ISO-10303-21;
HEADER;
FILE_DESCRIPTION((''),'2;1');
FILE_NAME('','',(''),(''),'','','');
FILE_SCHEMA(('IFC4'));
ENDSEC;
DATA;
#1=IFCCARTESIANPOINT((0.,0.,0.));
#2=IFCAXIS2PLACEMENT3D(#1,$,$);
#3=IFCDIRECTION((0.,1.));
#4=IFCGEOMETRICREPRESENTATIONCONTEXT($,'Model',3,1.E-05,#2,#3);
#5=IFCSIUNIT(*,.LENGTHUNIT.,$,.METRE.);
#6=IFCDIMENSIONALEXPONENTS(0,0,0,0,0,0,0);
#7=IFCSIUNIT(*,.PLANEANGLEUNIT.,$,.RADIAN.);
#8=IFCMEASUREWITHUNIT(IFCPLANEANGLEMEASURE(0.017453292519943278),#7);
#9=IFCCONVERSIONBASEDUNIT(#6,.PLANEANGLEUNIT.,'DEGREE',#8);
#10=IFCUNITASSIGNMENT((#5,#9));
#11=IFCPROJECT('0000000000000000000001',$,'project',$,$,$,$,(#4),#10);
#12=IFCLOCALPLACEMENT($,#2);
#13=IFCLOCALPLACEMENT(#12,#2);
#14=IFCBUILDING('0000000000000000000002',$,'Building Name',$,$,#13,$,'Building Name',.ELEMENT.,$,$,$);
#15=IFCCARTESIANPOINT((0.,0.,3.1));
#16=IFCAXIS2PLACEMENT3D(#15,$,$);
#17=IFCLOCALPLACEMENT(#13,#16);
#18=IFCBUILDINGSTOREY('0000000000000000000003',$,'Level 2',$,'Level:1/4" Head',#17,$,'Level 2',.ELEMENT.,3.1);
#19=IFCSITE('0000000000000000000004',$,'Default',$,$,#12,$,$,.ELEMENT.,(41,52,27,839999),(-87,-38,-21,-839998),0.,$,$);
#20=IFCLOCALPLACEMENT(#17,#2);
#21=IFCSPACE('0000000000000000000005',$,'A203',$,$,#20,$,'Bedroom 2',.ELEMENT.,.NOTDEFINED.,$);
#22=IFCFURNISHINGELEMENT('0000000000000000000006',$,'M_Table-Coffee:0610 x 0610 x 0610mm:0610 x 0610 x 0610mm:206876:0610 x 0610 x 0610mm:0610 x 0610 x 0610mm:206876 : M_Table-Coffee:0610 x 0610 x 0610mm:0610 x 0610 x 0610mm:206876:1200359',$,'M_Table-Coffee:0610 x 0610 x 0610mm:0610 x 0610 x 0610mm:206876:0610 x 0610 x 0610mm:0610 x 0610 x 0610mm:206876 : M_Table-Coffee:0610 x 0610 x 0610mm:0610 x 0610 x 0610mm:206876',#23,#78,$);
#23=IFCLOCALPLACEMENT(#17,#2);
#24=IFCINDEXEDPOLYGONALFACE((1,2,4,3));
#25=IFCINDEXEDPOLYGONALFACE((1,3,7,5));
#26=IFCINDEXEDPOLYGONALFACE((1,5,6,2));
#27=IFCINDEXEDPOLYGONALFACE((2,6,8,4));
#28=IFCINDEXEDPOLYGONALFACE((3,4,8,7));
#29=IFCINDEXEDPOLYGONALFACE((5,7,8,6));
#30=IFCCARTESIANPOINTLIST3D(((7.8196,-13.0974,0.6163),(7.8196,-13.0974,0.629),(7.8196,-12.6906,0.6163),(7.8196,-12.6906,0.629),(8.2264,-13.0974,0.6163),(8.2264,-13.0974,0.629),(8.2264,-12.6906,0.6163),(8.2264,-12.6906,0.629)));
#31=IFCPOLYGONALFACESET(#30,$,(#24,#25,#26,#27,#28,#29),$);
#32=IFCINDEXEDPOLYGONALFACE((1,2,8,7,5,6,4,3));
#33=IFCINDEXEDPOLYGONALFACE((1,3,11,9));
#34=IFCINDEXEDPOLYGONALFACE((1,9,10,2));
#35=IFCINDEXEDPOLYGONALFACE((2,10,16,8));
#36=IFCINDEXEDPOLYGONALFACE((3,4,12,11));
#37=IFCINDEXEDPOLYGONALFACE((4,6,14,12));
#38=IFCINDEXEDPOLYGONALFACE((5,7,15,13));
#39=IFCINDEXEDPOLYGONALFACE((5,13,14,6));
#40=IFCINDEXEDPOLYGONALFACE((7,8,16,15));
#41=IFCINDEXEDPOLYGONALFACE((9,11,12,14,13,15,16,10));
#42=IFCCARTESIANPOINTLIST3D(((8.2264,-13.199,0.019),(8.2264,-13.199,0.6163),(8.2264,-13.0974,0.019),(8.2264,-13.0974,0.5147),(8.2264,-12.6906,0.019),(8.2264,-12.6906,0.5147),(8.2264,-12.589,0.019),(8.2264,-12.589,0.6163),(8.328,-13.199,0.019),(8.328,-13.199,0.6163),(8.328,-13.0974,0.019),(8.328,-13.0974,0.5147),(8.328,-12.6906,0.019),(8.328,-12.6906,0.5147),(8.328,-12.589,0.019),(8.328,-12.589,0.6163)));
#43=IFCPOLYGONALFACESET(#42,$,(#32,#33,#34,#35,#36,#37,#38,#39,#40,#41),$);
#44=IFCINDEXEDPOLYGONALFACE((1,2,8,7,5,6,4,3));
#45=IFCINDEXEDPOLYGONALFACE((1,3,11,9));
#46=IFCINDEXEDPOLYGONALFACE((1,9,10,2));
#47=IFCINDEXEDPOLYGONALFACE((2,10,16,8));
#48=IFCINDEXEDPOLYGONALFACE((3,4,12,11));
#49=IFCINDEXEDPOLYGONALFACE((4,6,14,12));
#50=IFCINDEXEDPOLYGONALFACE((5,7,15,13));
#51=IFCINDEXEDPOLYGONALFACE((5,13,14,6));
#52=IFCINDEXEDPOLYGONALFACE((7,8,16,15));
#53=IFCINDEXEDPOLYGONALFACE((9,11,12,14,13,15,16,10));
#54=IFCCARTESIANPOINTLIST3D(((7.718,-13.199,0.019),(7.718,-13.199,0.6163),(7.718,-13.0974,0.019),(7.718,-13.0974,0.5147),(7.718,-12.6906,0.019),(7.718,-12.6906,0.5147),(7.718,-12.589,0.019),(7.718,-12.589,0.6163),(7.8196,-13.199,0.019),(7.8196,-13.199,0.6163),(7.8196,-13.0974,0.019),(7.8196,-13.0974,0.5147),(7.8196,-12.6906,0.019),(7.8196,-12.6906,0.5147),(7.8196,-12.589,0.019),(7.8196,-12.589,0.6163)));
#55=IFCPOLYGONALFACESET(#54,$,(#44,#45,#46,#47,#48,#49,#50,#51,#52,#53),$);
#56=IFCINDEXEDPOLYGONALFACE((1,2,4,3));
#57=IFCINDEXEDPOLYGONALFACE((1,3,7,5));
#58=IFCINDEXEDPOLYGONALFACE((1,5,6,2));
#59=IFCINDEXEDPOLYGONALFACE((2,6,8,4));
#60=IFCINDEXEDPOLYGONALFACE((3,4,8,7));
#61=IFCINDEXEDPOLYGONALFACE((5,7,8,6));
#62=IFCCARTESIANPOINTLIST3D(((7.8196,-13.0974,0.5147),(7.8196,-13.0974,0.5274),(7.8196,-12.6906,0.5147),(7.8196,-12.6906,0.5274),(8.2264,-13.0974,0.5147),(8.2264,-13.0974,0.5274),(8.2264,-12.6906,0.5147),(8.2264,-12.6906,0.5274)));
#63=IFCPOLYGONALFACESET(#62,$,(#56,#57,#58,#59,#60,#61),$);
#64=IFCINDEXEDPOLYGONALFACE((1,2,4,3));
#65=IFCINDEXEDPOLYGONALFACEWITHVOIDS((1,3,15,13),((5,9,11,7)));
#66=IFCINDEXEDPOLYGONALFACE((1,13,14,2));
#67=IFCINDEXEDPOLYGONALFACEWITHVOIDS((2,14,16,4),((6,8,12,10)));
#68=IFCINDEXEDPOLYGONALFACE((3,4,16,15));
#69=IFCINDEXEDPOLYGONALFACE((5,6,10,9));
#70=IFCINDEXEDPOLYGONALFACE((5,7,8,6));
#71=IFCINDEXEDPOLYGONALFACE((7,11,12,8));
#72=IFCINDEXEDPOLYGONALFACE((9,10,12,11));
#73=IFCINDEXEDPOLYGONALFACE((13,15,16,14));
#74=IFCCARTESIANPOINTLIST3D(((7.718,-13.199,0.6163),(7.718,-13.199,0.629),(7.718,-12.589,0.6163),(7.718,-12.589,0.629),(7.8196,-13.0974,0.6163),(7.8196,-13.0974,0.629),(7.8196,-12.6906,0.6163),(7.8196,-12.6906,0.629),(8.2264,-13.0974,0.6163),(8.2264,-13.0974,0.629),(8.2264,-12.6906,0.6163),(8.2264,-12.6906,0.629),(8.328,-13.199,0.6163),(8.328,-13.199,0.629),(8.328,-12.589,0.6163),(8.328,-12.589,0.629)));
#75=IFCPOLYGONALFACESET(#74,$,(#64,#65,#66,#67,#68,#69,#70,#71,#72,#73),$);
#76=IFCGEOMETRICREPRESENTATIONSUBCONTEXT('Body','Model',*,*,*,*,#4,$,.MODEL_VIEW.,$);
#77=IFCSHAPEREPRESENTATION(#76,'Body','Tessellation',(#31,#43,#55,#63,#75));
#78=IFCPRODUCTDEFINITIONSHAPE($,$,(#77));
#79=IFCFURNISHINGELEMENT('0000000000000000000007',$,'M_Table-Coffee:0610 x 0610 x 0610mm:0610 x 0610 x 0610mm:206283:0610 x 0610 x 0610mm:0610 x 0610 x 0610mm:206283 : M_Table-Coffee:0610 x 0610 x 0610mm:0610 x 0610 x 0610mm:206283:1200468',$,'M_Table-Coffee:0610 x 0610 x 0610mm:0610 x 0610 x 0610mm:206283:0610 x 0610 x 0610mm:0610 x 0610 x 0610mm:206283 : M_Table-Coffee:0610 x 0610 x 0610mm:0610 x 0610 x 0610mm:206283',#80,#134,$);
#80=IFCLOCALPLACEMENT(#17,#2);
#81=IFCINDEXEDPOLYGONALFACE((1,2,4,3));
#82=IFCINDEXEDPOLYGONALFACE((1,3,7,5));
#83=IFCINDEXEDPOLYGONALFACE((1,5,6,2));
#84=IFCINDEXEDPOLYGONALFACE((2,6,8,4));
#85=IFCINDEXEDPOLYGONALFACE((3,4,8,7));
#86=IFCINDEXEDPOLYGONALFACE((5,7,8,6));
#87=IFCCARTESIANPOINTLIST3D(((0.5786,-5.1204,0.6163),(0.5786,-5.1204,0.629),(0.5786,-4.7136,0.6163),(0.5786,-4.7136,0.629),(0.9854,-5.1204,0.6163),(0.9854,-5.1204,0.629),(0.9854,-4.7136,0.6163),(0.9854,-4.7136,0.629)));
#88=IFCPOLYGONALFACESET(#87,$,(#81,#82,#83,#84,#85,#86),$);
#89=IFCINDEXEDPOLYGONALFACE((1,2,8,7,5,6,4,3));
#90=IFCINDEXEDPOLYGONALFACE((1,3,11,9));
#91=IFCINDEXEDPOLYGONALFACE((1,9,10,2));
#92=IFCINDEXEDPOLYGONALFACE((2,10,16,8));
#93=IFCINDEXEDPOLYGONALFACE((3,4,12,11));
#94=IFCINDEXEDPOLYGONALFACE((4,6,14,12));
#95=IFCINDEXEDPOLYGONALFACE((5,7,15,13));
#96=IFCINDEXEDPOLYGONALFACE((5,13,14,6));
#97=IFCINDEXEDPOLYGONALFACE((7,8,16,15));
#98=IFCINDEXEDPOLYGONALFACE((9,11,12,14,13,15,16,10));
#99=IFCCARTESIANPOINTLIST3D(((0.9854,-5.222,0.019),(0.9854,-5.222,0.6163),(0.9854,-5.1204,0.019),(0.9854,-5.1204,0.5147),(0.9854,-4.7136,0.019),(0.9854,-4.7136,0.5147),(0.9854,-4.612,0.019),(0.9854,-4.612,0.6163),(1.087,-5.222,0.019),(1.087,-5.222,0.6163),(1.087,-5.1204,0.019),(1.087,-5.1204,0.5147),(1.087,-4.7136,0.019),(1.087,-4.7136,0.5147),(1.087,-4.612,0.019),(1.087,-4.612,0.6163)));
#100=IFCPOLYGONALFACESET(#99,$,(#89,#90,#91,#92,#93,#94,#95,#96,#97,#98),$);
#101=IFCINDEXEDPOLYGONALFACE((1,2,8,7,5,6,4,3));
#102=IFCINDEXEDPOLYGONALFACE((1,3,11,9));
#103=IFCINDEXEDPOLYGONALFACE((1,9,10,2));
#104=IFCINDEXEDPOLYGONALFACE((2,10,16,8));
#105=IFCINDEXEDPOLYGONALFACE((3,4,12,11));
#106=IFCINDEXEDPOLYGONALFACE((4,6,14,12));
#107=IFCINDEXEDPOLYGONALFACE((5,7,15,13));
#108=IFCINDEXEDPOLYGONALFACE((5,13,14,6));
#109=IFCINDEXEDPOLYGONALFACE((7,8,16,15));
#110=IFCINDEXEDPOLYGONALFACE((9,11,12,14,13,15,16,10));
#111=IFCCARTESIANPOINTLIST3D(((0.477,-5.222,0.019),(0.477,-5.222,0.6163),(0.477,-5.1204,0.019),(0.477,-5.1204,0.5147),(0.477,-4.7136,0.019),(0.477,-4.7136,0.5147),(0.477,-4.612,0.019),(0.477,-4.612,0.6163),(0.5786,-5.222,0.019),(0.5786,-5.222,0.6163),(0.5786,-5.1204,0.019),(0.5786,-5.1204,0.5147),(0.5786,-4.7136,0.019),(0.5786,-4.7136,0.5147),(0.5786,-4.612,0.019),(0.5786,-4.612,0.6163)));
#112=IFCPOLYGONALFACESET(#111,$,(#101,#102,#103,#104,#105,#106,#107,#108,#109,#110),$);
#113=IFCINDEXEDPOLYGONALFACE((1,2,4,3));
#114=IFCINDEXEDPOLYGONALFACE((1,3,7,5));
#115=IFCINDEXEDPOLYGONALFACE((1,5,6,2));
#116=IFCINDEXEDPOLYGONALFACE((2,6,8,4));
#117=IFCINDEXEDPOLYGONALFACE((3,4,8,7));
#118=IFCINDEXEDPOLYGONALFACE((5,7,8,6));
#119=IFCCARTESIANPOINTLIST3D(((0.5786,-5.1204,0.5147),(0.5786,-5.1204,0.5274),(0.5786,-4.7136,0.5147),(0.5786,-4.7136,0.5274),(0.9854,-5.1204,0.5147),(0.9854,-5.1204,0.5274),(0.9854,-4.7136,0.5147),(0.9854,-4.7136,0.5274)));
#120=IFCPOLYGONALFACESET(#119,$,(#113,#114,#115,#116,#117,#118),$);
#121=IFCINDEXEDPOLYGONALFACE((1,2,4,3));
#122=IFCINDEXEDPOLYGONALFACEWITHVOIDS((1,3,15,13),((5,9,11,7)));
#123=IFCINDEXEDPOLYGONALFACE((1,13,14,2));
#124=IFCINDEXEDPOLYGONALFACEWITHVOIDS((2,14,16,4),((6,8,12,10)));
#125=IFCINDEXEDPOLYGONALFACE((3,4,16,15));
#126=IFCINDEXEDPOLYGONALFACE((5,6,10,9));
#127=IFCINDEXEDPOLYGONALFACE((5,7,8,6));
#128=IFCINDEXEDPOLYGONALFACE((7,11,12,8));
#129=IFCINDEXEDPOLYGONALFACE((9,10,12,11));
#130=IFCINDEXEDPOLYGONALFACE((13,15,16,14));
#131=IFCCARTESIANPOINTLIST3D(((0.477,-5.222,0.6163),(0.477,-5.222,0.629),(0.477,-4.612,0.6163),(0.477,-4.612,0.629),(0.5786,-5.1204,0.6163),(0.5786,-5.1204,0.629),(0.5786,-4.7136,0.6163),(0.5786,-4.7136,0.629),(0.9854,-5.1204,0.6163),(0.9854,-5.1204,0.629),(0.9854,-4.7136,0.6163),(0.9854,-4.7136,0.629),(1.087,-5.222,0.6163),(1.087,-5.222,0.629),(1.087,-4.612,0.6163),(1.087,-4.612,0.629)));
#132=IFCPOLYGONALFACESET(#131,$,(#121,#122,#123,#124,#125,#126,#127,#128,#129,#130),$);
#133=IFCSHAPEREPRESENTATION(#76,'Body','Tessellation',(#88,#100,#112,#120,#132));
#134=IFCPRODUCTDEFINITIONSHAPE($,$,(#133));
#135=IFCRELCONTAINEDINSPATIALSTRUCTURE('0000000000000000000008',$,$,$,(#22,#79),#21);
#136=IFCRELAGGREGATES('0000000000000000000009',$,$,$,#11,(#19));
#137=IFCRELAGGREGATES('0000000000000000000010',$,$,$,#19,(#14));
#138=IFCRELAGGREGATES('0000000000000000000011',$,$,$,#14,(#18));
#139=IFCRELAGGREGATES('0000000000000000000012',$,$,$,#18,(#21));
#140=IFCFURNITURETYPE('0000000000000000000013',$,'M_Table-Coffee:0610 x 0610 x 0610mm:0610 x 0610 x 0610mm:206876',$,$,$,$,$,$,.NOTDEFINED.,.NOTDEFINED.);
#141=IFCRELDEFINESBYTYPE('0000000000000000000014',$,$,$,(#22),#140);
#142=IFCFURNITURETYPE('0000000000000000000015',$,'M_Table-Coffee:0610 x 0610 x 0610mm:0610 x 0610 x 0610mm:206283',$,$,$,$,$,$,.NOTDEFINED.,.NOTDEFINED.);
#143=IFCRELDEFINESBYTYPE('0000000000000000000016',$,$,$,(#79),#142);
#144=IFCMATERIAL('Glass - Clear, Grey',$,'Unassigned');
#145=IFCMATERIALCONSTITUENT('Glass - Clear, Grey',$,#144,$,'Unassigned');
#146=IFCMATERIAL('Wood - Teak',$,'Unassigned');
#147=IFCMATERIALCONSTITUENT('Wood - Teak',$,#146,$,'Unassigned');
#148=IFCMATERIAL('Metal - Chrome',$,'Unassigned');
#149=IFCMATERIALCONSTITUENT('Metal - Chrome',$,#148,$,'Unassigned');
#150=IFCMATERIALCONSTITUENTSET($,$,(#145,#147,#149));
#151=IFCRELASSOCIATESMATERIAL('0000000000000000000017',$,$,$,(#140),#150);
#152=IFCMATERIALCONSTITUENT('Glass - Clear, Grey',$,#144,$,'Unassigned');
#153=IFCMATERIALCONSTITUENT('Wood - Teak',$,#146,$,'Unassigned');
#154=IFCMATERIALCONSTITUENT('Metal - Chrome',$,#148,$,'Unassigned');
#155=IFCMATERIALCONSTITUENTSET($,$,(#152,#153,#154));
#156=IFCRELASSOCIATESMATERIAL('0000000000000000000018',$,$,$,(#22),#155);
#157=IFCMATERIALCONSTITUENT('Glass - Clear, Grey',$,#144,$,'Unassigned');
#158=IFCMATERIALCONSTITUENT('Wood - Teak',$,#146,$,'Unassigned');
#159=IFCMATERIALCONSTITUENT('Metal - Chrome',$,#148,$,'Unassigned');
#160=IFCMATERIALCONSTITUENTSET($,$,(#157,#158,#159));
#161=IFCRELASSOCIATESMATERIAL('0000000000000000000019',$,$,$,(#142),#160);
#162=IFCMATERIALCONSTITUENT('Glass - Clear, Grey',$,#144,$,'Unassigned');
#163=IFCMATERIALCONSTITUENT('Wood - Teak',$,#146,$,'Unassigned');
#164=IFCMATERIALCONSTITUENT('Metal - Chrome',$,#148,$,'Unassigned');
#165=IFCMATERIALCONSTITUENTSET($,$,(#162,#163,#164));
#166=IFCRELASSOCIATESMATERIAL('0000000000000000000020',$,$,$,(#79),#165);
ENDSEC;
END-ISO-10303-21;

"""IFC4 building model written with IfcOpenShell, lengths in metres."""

from ifc_helpers import new_model, entity, si_unit, converted_unit, direction, frame, origin, place, context, subcontext, project, spatial, indexed_curve, outline, extrude, source, transform, mapped, material, constituent, constituent_set, type_object, type_shapes, element, save


model = new_model("IFC4")

# Units and contexts
model_context = context("Model", 3, precision=1e-05, world=origin(), true_north=direction((0.0, 1.0)))
body_context = subcontext(model_context, "Body", "Model", "MODEL_VIEW")
ifc_project = project(units=[si_unit("LENGTHUNIT", "METRE"), converted_unit("PLANEANGLEUNIT", "DEGREE", entity("IfcPlaneAngleMeasure", 0.017453292519943278), si_unit("PLANEANGLEUNIT", "RADIAN"), dimensions=[0, 0, 0, 0, 0, 0, 0])], contexts=[model_context])

# Site, building, storey
site_placement = place(None, origin())
site = spatial("IfcSite", under=ifc_project, at=site_placement, Name="Default", CompositionType="ELEMENT", RefLatitude=(41, 52, 27, 839999), RefLongitude=(-87, -38, -21, -839998), RefElevation=0.0)
building_placement = place(site_placement, origin())
building = spatial("IfcBuilding", under=site, at=building_placement, Name="Building Name", LongName="Building Name", CompositionType="ELEMENT")
storey_placement = place(building_placement, frame((0.0, 0.0, 3.1)))
storey = spatial("IfcBuildingStorey", under=building, at=storey_placement, Name="Level 2", ObjectType="Level:1/4\" Head", LongName="Level 2", CompositionType="ELEMENT", Elevation=3.1)

# Shared definitions
space_placement = place(storey_placement, origin())
space = spatial("IfcSpace", under=storey, at=space_placement, Name="A203", LongName="Bedroom 2", CompositionType="ELEMENT", PredefinedType="NOTDEFINED")

# Furnishing elements
ifc_material_1 = material(Name="Glass - Clear, Grey", Category="Unassigned")
ifc_constituent_1 = constituent(ifc_material_1, Name="Glass - Clear, Grey", Category="Unassigned")
ifc_material_2 = material(Name="Wood - Teak", Category="Unassigned")
ifc_constituent_2 = constituent(ifc_material_2, Name="Wood - Teak", Category="Unassigned")
ifc_material_3 = material(Name="Metal - Chrome", Category="Unassigned")
ifc_constituent_3 = constituent(ifc_material_3, Name="Metal - Chrome", Category="Unassigned")
ifc_constituent_set_1 = constituent_set(constituents=[ifc_constituent_1, ifc_constituent_2, ifc_constituent_3])
ifc_constituent_4 = constituent(ifc_material_1, Name="Glass - Clear, Grey", Category="Unassigned")
ifc_constituent_5 = constituent(ifc_material_2, Name="Wood - Teak", Category="Unassigned")
ifc_constituent_6 = constituent(ifc_material_3, Name="Metal - Chrome", Category="Unassigned")
ifc_constituent_set_2 = constituent_set(constituents=[ifc_constituent_4, ifc_constituent_5, ifc_constituent_6])
furniture_type_1 = type_object("IfcFurnitureType", Name="M_Table-Coffee:0610 x 0610 x 0610mm:0610 x 0610 x 0610mm:206876", AssemblyPlace="NOTDEFINED", PredefinedType="NOTDEFINED", material=ifc_constituent_set_2)
shared_shape_1 = source(origin(), body_context, "Body", "SweptSolid", [
    extrude(outline(indexed_curve([(-0.2034, -0.2034), (0.2034, -0.2034), (0.2034, 0.2034), (-0.2034, 0.2034), (-0.2034, -0.2034)], self_intersect=False)), frame((8.023, -12.894, 3.7163), z_axis=(0.0, 0.0, 1.0), x_axis=(0.0, -1.0, 0.0)), (0.0, 0.0, 1.0), 0.0127),
    extrude(outline(indexed_curve([(-0.305, -0.324), (0.305, -0.324), (0.305, 0.2732), (0.2034, 0.2732), (0.2034, -0.2225), (-0.2034, -0.2225), (-0.2034, 0.2732), (-0.305, 0.2732), (-0.305, -0.324)], self_intersect=False)), frame((8.2264, -12.894, 3.3923), z_axis=(1.0, 0.0, 0.0), x_axis=(0.0, -1.0, 0.0)), (0.0, 0.0, 1.0), 0.1016),
    extrude(outline(indexed_curve([(-0.3241, -0.305), (0.2733, -0.305), (0.2733, -0.2034), (-0.2224, -0.2034), (-0.2224, 0.2034), (0.2733, 0.2034), (0.2733, 0.305), (-0.3241, 0.305), (-0.3241, -0.305)], self_intersect=False)), frame((7.718, -12.894, 3.3923), z_axis=(1.0, 0.0, 0.0), x_axis=(0.0, 0.0, -1.0)), (0.0, 0.0, 1.0), 0.1016),
    extrude(outline(indexed_curve([(-0.2034, -0.2034), (0.2034, -0.2034), (0.2034, 0.2034), (-0.2034, 0.2034), (-0.2034, -0.2034)], self_intersect=False)), frame((8.023, -12.894, 3.6147), z_axis=(0.0, 0.0, 1.0), x_axis=(0.0, -1.0, 0.0)), (0.0, 0.0, 1.0), 0.0127),
    extrude(outline(indexed_curve([(-0.305, -0.305), (0.305, -0.305), (0.305, 0.305), (-0.305, 0.305), (-0.305, -0.305)], self_intersect=False), holes=[indexed_curve([(0.2034, 0.2034), (0.2034, -0.2034), (-0.2034, -0.2034), (-0.2034, 0.2034), (0.2034, 0.2034)], self_intersect=False)]), frame((8.023, -12.894, 3.7163), z_axis=(0.0, 0.0, 1.0), x_axis=(0.0, -1.0, 0.0)), (0.0, 0.0, 1.0), 0.0127),
])
type_shapes(furniture_type_1, [shared_shape_1])
furnishing_1_placement = place(space_placement, frame((0.0, 0.0, -3.1)))
element("IfcFurnishingElement", 1, at=furnishing_1_placement, inside=space, type_object=furniture_type_1, material=ifc_constituent_set_1, Name="M_Table-Coffee:0610 x 0610 x 0610mm:0610 x 0610 x 0610mm:206876:0610 x 0610 x 0610mm:0610 x 0610 x 0610mm:206876 : M_Table-Coffee:0610 x 0610 x 0610mm:0610 x 0610 x 0610mm:206876:1200359", ObjectType="M_Table-Coffee:0610 x 0610 x 0610mm:0610 x 0610 x 0610mm:206876:0610 x 0610 x 0610mm:0610 x 0610 x 0610mm:206876 : M_Table-Coffee:0610 x 0610 x 0610mm:0610 x 0610 x 0610mm:206876", context=body_context, shape_type="MappedRepresentation", body=[
    mapped(shared_shape_1, transform((0.0, 0.0, 0.0), scale=1.0)),
])
ifc_constituent_7 = constituent(ifc_material_1, Name="Glass - Clear, Grey", Category="Unassigned")
ifc_constituent_8 = constituent(ifc_material_2, Name="Wood - Teak", Category="Unassigned")
ifc_constituent_9 = constituent(ifc_material_3, Name="Metal - Chrome", Category="Unassigned")
ifc_constituent_set_3 = constituent_set(constituents=[ifc_constituent_7, ifc_constituent_8, ifc_constituent_9])
ifc_constituent_10 = constituent(ifc_material_1, Name="Glass - Clear, Grey", Category="Unassigned")
ifc_constituent_11 = constituent(ifc_material_2, Name="Wood - Teak", Category="Unassigned")
ifc_constituent_12 = constituent(ifc_material_3, Name="Metal - Chrome", Category="Unassigned")
ifc_constituent_set_4 = constituent_set(constituents=[ifc_constituent_10, ifc_constituent_11, ifc_constituent_12])
furniture_type_2 = type_object("IfcFurnitureType", Name="M_Table-Coffee:0610 x 0610 x 0610mm:0610 x 0610 x 0610mm:206283", AssemblyPlace="NOTDEFINED", PredefinedType="NOTDEFINED", material=ifc_constituent_set_4)
shared_shape_2 = source(origin(), body_context, "Body", "SweptSolid", [
    extrude(outline(indexed_curve([(-0.2034, -0.2034), (0.2034, -0.2034), (0.2034, 0.2034), (-0.2034, 0.2034), (-0.2034, -0.2034)], self_intersect=False)), frame((0.782, -4.917, 3.7163), z_axis=(0.0, 0.0, 1.0), x_axis=(0.0, -1.0, 0.0)), (0.0, 0.0, 1.0), 0.0127),
    extrude(outline(indexed_curve([(-0.305, -0.324), (0.305, -0.324), (0.305, 0.2732), (0.2034, 0.2732), (0.2034, -0.2225), (-0.2034, -0.2225), (-0.2034, 0.2732), (-0.305, 0.2732), (-0.305, -0.324)], self_intersect=False)), frame((0.9854, -4.917, 3.3923), z_axis=(1.0, 0.0, 0.0), x_axis=(0.0, -1.0, 0.0)), (0.0, 0.0, 1.0), 0.1016),
    extrude(outline(indexed_curve([(-0.3241, -0.305), (0.2733, -0.305), (0.2733, -0.2034), (-0.2224, -0.2034), (-0.2224, 0.2034), (0.2733, 0.2034), (0.2733, 0.305), (-0.3241, 0.305), (-0.3241, -0.305)], self_intersect=False)), frame((0.477, -4.917, 3.3923), z_axis=(1.0, 0.0, 0.0), x_axis=(0.0, 0.0, -1.0)), (0.0, 0.0, 1.0), 0.1016),
    extrude(outline(indexed_curve([(-0.2034, -0.2034), (0.2034, -0.2034), (0.2034, 0.2034), (-0.2034, 0.2034), (-0.2034, -0.2034)], self_intersect=False)), frame((0.782, -4.917, 3.6147), z_axis=(0.0, 0.0, 1.0), x_axis=(0.0, -1.0, 0.0)), (0.0, 0.0, 1.0), 0.0127),
    extrude(outline(indexed_curve([(-0.305, -0.305), (0.305, -0.305), (0.305, 0.305), (-0.305, 0.305), (-0.305, -0.305)], self_intersect=False), holes=[indexed_curve([(0.2034, 0.2034), (0.2034, -0.2034), (-0.2034, -0.2034), (-0.2034, 0.2034), (0.2034, 0.2034)], self_intersect=False)]), frame((0.782, -4.917, 3.7163), z_axis=(0.0, 0.0, 1.0), x_axis=(0.0, -1.0, 0.0)), (0.0, 0.0, 1.0), 0.0127),
])
type_shapes(furniture_type_2, [shared_shape_2])
furnishing_2_placement = place(space_placement, frame((0.0, 0.0, -3.1)))
element("IfcFurnishingElement", 2, at=furnishing_2_placement, inside=space, type_object=furniture_type_2, material=ifc_constituent_set_3, Name="M_Table-Coffee:0610 x 0610 x 0610mm:0610 x 0610 x 0610mm:206283:0610 x 0610 x 0610mm:0610 x 0610 x 0610mm:206283 : M_Table-Coffee:0610 x 0610 x 0610mm:0610 x 0610 x 0610mm:206283:1200468", ObjectType="M_Table-Coffee:0610 x 0610 x 0610mm:0610 x 0610 x 0610mm:206283:0610 x 0610 x 0610mm:0610 x 0610 x 0610mm:206283 : M_Table-Coffee:0610 x 0610 x 0610mm:0610 x 0610 x 0610mm:206283", context=body_context, shape_type="MappedRepresentation", body=[
    mapped(shared_shape_2, transform((0.0, 0.0, 0.0), scale=1.0)),
])

save(model, "model.ifc")
